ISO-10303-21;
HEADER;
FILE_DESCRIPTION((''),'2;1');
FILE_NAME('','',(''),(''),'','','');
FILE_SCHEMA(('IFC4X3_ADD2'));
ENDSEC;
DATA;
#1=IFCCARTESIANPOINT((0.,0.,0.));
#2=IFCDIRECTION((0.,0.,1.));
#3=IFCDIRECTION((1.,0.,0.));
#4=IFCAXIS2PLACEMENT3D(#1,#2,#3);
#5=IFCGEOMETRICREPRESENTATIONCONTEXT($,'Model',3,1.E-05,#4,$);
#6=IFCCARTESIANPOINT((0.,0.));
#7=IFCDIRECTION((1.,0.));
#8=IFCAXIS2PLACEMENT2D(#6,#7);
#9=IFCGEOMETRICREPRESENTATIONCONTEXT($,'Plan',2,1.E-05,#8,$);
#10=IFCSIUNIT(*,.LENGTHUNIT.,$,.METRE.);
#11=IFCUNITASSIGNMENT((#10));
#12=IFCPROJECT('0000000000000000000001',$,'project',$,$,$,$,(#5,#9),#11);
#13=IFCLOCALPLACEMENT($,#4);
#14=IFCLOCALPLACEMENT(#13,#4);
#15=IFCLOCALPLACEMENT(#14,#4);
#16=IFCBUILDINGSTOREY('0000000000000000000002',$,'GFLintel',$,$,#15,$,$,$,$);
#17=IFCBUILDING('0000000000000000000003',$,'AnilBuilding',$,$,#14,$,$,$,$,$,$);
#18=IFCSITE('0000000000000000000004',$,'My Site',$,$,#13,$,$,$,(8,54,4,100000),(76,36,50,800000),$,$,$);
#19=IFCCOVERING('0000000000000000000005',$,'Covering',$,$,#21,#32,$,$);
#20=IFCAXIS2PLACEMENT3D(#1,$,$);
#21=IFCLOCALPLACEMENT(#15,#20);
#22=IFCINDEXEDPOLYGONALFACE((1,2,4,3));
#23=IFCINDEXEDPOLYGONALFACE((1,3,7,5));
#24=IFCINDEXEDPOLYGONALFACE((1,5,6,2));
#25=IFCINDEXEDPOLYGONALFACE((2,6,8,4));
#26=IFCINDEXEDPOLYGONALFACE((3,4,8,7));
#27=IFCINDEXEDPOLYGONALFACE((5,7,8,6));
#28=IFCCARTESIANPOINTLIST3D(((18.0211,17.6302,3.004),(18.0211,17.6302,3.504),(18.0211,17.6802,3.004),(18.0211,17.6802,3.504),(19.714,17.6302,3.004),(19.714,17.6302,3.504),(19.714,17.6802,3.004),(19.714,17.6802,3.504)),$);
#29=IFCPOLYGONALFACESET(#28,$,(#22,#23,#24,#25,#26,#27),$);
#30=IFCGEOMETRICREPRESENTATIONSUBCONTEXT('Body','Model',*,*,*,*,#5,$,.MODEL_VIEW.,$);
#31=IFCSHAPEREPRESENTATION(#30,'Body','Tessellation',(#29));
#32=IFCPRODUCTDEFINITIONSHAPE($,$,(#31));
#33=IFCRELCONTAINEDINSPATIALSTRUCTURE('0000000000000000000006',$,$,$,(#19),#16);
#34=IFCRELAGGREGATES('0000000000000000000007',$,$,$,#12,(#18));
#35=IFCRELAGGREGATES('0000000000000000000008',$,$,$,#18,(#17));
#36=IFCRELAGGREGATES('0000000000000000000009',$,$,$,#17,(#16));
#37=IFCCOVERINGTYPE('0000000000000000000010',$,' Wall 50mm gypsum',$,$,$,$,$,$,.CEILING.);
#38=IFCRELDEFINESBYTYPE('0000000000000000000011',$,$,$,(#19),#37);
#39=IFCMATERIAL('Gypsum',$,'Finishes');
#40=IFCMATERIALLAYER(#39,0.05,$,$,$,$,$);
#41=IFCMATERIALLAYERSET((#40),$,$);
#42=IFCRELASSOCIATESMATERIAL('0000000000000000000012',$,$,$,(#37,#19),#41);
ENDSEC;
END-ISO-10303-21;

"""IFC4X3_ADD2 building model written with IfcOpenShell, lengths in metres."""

from ifc_helpers import new_model, si_unit, frame, origin_with_axes, origin_2d_with_axis, place, context, subcontext, project, spatial, line, indexed_curve, outline, extrude, material, layer, layer_set, layer_usage, type_object, element, save


model = new_model("IFC4X3_ADD2")

# Units and contexts
model_context = context("Model", 3, precision=1e-05, world=origin_with_axes())
plan_context = context("Plan", 2, precision=1e-05, world=origin_2d_with_axis())
body_context = subcontext(model_context, "Body", "Model", "MODEL_VIEW")
ifc_project = project(units=[si_unit("LENGTHUNIT", "METRE")], contexts=[model_context, plan_context])

# Site, building, storey
site_placement = place(None, origin_with_axes())
site = spatial("IfcSite", under=ifc_project, at=site_placement, Name="My Site", RefLatitude=(8, 54, 4, 100000), RefLongitude=(76, 36, 50, 800000))
building_placement = place(site_placement, origin_with_axes())
building = spatial("IfcBuilding", under=site, at=building_placement, Name="AnilBuilding")
storey_placement = place(building_placement, origin_with_axes())
storey = spatial("IfcBuildingStorey", under=building, at=storey_placement, Name="GFLintel")

# Covering
ifc_material_1 = material(Name="Gypsum", Category="Finishes")
ifc_layer_1 = layer(ifc_material_1, 0.05)
ifc_layer_set_1 = layer_set([ifc_layer_1])
ifc_layer_usage_1 = layer_usage(ifc_layer_set_1, "AXIS2", "POSITIVE", 0.0)
covering_type_1 = type_object("IfcCoveringType", Name=" Wall 50mm gypsum", PredefinedType="CEILING", material=ifc_layer_set_1)
covering_1_placement = place(storey_placement, frame((19.714, 17.6802, 3.004), z_axis=(0.0, 0.0, 1.0), x_axis=(-1.0, 0.0, 0.0)))
element("IfcCovering", 1, at=covering_1_placement, inside=storey, type_object=covering_type_1, material=ifc_layer_usage_1, Name="Covering", context=body_context, shape_type="SweptSolid", body=[
    extrude(outline(indexed_curve([(0.0, 0.0), (0.0, 0.05), (1.6929, 0.05), (1.6929, 0.0)], segments=[line(1, 2, 3, 4, 1)])), origin_with_axes(), (0.0, 0.0, 1.0), 0.5),
])

save(model, "model.ifc")
